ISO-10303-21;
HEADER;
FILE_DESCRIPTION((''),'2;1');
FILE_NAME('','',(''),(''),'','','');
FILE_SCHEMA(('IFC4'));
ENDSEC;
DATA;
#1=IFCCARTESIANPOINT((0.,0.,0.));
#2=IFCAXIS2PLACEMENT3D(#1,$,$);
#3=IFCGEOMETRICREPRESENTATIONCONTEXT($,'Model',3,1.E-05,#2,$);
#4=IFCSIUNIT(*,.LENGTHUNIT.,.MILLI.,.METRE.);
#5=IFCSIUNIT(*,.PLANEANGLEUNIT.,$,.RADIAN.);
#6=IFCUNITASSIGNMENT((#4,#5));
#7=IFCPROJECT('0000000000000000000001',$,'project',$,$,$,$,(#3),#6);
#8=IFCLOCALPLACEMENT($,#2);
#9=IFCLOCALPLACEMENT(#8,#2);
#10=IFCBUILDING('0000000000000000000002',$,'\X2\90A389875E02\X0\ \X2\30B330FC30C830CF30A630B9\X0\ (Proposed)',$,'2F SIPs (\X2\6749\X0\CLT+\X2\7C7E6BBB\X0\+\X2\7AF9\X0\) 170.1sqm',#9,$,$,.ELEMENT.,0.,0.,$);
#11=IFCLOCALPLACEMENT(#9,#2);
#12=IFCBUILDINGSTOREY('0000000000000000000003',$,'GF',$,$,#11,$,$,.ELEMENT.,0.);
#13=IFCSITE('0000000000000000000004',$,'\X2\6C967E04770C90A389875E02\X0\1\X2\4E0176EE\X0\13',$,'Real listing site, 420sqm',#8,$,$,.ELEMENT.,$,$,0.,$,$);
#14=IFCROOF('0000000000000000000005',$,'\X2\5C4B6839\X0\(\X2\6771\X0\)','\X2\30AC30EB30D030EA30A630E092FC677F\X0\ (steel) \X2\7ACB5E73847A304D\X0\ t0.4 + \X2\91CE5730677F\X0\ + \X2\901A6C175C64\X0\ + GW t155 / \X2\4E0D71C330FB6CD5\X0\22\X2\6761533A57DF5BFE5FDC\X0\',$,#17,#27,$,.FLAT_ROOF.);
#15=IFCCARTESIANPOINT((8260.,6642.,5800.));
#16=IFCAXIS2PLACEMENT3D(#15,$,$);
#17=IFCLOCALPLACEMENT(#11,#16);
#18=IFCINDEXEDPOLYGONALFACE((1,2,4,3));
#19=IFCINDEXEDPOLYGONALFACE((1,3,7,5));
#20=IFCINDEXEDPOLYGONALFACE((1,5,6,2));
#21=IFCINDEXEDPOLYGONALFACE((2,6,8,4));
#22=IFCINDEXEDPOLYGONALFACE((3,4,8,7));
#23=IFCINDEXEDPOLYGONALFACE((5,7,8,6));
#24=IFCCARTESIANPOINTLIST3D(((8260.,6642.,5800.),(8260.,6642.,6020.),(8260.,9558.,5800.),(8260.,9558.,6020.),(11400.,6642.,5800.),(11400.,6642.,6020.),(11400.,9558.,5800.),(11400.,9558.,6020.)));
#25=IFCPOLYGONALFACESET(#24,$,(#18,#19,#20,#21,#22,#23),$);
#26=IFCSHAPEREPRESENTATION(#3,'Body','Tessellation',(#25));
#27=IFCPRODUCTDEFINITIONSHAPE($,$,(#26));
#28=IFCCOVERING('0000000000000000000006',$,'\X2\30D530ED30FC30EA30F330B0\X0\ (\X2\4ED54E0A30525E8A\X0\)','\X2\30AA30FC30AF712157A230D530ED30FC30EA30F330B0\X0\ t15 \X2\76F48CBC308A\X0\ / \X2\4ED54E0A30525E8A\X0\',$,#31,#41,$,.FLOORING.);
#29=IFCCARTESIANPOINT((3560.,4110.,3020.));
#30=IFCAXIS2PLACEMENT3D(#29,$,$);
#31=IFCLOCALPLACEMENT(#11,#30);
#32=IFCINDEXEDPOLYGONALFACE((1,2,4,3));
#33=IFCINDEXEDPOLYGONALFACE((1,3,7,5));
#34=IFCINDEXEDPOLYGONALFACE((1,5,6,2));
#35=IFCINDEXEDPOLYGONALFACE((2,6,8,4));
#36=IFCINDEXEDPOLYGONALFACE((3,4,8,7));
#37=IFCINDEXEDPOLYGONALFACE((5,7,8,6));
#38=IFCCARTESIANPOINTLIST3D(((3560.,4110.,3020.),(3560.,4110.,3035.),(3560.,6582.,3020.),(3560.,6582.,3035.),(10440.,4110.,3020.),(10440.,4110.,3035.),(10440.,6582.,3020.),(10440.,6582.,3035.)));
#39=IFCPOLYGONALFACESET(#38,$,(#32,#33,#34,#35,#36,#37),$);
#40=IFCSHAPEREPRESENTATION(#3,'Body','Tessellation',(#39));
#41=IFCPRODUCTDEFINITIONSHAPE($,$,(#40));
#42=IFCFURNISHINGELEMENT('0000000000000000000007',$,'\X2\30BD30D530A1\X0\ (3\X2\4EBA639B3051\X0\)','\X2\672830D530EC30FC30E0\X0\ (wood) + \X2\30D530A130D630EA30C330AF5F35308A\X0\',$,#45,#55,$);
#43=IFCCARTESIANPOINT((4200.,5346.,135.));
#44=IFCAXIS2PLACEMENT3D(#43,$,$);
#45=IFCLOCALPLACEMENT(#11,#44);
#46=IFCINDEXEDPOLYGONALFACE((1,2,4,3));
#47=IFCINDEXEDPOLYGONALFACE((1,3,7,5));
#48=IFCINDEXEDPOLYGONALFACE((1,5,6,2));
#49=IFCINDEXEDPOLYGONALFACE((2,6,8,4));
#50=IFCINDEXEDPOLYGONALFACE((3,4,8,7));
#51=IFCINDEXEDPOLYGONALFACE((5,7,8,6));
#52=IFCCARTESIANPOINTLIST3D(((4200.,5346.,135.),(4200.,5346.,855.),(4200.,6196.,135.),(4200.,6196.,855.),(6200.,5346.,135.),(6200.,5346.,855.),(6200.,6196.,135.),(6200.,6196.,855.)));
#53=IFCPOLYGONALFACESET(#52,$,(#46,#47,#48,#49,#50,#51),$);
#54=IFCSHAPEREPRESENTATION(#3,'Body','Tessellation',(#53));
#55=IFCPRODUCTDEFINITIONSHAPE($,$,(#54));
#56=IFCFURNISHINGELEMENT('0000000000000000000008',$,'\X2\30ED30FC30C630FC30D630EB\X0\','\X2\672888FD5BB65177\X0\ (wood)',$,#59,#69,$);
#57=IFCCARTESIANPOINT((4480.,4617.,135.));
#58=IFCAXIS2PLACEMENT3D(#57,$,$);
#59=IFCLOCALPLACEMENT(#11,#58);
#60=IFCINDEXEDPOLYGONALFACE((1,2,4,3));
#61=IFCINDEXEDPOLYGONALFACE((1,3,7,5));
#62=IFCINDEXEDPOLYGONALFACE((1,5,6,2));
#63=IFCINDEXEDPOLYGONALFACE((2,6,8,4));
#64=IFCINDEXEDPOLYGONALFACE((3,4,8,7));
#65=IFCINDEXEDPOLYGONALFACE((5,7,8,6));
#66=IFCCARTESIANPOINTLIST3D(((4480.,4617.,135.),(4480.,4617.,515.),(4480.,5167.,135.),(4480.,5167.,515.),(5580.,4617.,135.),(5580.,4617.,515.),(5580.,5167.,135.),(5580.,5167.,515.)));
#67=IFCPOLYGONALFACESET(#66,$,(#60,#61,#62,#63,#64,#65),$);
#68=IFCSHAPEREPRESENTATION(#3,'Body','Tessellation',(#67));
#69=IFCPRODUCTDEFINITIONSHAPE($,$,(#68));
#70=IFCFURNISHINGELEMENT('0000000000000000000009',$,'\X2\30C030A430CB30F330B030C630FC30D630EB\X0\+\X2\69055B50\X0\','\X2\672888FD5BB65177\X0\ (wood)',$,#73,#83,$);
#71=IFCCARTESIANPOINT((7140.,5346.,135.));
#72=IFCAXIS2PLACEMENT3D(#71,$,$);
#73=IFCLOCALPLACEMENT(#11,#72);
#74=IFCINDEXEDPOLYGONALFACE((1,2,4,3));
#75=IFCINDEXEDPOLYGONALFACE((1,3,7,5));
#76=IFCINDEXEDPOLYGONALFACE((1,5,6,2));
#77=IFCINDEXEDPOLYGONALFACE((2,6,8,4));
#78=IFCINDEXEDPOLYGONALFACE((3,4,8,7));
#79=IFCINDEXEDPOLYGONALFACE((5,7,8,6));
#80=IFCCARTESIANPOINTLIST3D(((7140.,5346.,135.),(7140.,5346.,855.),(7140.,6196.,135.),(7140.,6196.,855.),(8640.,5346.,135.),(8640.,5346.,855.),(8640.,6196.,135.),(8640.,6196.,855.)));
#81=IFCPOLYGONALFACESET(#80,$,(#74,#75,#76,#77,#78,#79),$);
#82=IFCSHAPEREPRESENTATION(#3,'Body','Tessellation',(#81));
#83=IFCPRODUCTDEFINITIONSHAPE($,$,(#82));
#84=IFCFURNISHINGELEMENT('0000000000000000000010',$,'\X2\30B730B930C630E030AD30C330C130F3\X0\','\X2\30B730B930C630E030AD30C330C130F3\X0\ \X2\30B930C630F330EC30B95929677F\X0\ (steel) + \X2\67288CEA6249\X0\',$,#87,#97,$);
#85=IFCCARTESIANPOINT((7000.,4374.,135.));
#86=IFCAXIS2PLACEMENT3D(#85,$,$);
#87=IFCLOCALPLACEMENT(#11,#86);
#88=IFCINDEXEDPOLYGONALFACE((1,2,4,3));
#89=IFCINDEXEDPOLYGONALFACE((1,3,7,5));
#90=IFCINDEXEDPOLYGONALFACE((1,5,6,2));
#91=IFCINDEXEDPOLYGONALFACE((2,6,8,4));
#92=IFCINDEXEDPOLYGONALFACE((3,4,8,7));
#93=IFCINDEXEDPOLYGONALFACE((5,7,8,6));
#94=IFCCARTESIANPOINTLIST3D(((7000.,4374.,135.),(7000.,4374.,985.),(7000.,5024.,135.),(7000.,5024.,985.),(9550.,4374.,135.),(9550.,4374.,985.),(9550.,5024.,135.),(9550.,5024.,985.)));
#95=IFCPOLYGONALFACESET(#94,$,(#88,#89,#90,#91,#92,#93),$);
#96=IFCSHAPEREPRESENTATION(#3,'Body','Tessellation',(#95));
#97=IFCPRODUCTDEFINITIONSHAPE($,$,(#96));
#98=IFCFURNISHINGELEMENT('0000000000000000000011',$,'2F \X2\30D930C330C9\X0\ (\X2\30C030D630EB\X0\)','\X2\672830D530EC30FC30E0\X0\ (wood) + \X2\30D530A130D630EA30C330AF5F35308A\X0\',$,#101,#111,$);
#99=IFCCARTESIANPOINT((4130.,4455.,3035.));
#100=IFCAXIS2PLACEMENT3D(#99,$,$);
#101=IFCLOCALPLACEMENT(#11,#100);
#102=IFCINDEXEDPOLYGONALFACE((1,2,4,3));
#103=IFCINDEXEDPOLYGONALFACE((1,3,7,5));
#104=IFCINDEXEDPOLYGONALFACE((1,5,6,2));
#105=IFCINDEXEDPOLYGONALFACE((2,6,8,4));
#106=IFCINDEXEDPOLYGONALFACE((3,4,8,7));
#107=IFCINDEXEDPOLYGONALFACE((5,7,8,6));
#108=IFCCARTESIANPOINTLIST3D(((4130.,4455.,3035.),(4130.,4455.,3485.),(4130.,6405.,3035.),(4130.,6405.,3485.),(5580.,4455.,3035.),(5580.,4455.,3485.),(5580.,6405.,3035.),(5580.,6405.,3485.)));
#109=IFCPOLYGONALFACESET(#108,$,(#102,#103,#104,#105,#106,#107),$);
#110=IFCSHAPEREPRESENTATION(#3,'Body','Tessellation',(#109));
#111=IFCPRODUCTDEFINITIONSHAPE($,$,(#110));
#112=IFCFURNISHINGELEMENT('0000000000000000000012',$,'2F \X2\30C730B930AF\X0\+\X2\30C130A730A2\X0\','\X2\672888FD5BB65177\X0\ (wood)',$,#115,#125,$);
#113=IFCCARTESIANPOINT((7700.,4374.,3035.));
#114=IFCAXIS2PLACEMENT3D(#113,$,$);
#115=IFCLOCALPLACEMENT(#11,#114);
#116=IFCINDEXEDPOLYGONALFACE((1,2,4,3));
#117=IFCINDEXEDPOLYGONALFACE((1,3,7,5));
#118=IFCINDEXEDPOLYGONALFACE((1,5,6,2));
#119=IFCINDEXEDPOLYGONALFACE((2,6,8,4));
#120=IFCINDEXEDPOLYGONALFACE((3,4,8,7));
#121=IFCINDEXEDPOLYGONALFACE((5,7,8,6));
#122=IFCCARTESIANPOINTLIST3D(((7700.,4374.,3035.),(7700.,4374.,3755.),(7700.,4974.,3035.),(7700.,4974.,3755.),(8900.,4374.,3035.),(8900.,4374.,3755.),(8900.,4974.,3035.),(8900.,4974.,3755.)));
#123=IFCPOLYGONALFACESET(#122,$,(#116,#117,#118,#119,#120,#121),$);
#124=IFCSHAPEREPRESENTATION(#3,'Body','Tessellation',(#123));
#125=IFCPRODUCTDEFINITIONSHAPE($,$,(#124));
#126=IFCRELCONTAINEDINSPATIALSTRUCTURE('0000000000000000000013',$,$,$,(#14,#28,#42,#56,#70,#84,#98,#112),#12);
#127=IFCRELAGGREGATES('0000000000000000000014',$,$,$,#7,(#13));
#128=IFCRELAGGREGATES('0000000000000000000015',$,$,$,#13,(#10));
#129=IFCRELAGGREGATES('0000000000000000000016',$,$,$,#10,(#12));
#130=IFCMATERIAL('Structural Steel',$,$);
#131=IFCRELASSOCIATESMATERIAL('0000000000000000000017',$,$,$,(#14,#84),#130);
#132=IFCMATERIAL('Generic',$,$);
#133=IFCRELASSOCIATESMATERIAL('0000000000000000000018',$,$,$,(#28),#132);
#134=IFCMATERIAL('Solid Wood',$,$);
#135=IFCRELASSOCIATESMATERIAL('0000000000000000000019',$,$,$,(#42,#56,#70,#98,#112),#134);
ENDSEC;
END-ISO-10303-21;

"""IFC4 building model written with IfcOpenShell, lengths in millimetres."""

from ifc_helpers import new_model, si_unit, frame, frame_2d, origin, place, context, project, spatial, rectangle, extrude, material, element, save


model = new_model("IFC4")

# Units and contexts
model_context = context("Model", 3, precision=1e-05, world=origin())
ifc_project = project(units=[si_unit("LENGTHUNIT", "METRE", prefix="MILLI"), si_unit("PLANEANGLEUNIT", "RADIAN")], contexts=[model_context])

# Site, building, storey
site_placement = place(None, origin())
site = spatial("IfcSite", under=ifc_project, at=site_placement, Name="沖縄県那覇市1丁目13", ObjectType="Real listing site, 420sqm", CompositionType="ELEMENT", RefElevation=0.0)
building_placement = place(site_placement, origin())
building = spatial("IfcBuilding", under=site, at=building_placement, Name="那覇市 コートハウス (Proposed)", ObjectType="2F SIPs (杉CLT+籾殻+竹) 170.1sqm", CompositionType="ELEMENT", ElevationOfRefHeight=0.0, ElevationOfTerrain=0.0)
storey_placement = place(building_placement, origin())
storey = spatial("IfcBuildingStorey", under=building, at=storey_placement, Name="GF", CompositionType="ELEMENT", Elevation=0.0)

# Shared definitions
ifc_material_1 = material(Name="Solid Wood")

# Shared definitions
ifc_material_2 = material(Name="Generic")

# Roof
ifc_material_3 = material(Name="Structural Steel")
roof_placement = place(storey_placement, frame((8260.0, 6642.0, 5800.0)))
element("IfcRoof", 1, at=roof_placement, inside=storey, material=ifc_material_3, Name="屋根(東)", Description="ガルバリウム鋼板 (steel) 立平葺き t0.4 + 野地板 + 通気層 + GW t155 / 不燃・法22条区域対応", PredefinedType="FLAT_ROOF", context=model_context, shape_type="SweptSolid", body=[
    extrude(rectangle(XDim=3140.0, YDim=2916.0, at=frame_2d((1570.0, 1458.0))), frame((8260.0, 6642.0, 5800.0)), (0.0, 0.0, 1.0), 220.0),
])

# Covering
covering_placement = place(storey_placement, frame((3560.0, 4110.0, 3020.0)))
element("IfcCovering", 2, at=covering_placement, inside=storey, material=ifc_material_2, Name="フローリング (仕上げ床)", Description="オーク無垢フローリング t15 直貼り / 仕上げ床", PredefinedType="FLOORING", context=model_context, shape_type="SweptSolid", body=[
    extrude(rectangle(XDim=6880.0, YDim=2472.0, at=frame_2d((3440.0, 1236.0))), frame((3560.0, 4110.0, 3020.0)), (0.0, 0.0, 1.0), 15.0),
])

# Furnishing elements
furnishing_1_placement = place(storey_placement, frame((4200.0, 5346.0, 135.0)))
element("IfcFurnishingElement", 3, at=furnishing_1_placement, inside=storey, material=ifc_material_1, Name="ソファ (3人掛け)", Description="木フレーム (wood) + ファブリック張り", context=model_context, shape_type="SweptSolid", body=[
    extrude(rectangle(XDim=2000.0, YDim=850.0, at=frame_2d((1000.0, 425.0))), frame((4200.0, 5346.0, 135.0)), (0.0, 0.0, 1.0), 720.0),
])
furnishing_2_placement = place(storey_placement, frame((4480.0, 4617.0, 135.0)))
element("IfcFurnishingElement", 4, at=furnishing_2_placement, inside=storey, material=ifc_material_1, Name="ローテーブル", Description="木製家具 (wood)", context=model_context, shape_type="SweptSolid", body=[
    extrude(rectangle(XDim=1100.0, YDim=550.0, at=frame_2d((550.0, 275.0))), frame((4480.0, 4617.0, 135.0)), (0.0, 0.0, 1.0), 380.0),
])
furnishing_3_placement = place(storey_placement, frame((7140.0, 5346.0, 135.0)))
element("IfcFurnishingElement", 5, at=furnishing_3_placement, inside=storey, material=ifc_material_1, Name="ダイニングテーブル+椅子", Description="木製家具 (wood)", context=model_context, shape_type="SweptSolid", body=[
    extrude(rectangle(XDim=1500.0, YDim=850.0, at=frame_2d((750.0, 425.0))), frame((7140.0, 5346.0, 135.0)), (0.0, 0.0, 1.0), 720.0),
])
furnishing_4_placement = place(storey_placement, frame((7000.0, 4374.0, 135.0)))
element("IfcFurnishingElement", 6, at=furnishing_4_placement, inside=storey, material=ifc_material_3, Name="システムキッチン", Description="システムキッチン ステンレス天板 (steel) + 木質扉", context=model_context, shape_type="SweptSolid", body=[
    extrude(rectangle(XDim=2550.0, YDim=650.0, at=frame_2d((1275.0, 325.0))), frame((7000.0, 4374.0, 135.0)), (0.0, 0.0, 1.0), 850.0),
])
furnishing_5_placement = place(storey_placement, frame((4130.0, 4455.0, 3035.0)))
element("IfcFurnishingElement", 7, at=furnishing_5_placement, inside=storey, material=ifc_material_1, Name="2F ベッド (ダブル)", Description="木フレーム (wood) + ファブリック張り", context=model_context, shape_type="SweptSolid", body=[
    extrude(rectangle(XDim=1450.0, YDim=1950.0, at=frame_2d((725.0, 975.0))), frame((4130.0, 4455.0, 3035.0)), (0.0, 0.0, 1.0), 450.0),
])
furnishing_6_placement = place(storey_placement, frame((7700.0, 4374.0, 3035.0)))
element("IfcFurnishingElement", 8, at=furnishing_6_placement, inside=storey, material=ifc_material_1, Name="2F デスク+チェア", Description="木製家具 (wood)", context=model_context, shape_type="SweptSolid", body=[
    extrude(rectangle(XDim=1200.0, YDim=600.0, at=frame_2d((600.0, 300.0))), frame((7700.0, 4374.0, 3035.0)), (0.0, 0.0, 1.0), 720.0),
])

save(model, "model.ifc")
